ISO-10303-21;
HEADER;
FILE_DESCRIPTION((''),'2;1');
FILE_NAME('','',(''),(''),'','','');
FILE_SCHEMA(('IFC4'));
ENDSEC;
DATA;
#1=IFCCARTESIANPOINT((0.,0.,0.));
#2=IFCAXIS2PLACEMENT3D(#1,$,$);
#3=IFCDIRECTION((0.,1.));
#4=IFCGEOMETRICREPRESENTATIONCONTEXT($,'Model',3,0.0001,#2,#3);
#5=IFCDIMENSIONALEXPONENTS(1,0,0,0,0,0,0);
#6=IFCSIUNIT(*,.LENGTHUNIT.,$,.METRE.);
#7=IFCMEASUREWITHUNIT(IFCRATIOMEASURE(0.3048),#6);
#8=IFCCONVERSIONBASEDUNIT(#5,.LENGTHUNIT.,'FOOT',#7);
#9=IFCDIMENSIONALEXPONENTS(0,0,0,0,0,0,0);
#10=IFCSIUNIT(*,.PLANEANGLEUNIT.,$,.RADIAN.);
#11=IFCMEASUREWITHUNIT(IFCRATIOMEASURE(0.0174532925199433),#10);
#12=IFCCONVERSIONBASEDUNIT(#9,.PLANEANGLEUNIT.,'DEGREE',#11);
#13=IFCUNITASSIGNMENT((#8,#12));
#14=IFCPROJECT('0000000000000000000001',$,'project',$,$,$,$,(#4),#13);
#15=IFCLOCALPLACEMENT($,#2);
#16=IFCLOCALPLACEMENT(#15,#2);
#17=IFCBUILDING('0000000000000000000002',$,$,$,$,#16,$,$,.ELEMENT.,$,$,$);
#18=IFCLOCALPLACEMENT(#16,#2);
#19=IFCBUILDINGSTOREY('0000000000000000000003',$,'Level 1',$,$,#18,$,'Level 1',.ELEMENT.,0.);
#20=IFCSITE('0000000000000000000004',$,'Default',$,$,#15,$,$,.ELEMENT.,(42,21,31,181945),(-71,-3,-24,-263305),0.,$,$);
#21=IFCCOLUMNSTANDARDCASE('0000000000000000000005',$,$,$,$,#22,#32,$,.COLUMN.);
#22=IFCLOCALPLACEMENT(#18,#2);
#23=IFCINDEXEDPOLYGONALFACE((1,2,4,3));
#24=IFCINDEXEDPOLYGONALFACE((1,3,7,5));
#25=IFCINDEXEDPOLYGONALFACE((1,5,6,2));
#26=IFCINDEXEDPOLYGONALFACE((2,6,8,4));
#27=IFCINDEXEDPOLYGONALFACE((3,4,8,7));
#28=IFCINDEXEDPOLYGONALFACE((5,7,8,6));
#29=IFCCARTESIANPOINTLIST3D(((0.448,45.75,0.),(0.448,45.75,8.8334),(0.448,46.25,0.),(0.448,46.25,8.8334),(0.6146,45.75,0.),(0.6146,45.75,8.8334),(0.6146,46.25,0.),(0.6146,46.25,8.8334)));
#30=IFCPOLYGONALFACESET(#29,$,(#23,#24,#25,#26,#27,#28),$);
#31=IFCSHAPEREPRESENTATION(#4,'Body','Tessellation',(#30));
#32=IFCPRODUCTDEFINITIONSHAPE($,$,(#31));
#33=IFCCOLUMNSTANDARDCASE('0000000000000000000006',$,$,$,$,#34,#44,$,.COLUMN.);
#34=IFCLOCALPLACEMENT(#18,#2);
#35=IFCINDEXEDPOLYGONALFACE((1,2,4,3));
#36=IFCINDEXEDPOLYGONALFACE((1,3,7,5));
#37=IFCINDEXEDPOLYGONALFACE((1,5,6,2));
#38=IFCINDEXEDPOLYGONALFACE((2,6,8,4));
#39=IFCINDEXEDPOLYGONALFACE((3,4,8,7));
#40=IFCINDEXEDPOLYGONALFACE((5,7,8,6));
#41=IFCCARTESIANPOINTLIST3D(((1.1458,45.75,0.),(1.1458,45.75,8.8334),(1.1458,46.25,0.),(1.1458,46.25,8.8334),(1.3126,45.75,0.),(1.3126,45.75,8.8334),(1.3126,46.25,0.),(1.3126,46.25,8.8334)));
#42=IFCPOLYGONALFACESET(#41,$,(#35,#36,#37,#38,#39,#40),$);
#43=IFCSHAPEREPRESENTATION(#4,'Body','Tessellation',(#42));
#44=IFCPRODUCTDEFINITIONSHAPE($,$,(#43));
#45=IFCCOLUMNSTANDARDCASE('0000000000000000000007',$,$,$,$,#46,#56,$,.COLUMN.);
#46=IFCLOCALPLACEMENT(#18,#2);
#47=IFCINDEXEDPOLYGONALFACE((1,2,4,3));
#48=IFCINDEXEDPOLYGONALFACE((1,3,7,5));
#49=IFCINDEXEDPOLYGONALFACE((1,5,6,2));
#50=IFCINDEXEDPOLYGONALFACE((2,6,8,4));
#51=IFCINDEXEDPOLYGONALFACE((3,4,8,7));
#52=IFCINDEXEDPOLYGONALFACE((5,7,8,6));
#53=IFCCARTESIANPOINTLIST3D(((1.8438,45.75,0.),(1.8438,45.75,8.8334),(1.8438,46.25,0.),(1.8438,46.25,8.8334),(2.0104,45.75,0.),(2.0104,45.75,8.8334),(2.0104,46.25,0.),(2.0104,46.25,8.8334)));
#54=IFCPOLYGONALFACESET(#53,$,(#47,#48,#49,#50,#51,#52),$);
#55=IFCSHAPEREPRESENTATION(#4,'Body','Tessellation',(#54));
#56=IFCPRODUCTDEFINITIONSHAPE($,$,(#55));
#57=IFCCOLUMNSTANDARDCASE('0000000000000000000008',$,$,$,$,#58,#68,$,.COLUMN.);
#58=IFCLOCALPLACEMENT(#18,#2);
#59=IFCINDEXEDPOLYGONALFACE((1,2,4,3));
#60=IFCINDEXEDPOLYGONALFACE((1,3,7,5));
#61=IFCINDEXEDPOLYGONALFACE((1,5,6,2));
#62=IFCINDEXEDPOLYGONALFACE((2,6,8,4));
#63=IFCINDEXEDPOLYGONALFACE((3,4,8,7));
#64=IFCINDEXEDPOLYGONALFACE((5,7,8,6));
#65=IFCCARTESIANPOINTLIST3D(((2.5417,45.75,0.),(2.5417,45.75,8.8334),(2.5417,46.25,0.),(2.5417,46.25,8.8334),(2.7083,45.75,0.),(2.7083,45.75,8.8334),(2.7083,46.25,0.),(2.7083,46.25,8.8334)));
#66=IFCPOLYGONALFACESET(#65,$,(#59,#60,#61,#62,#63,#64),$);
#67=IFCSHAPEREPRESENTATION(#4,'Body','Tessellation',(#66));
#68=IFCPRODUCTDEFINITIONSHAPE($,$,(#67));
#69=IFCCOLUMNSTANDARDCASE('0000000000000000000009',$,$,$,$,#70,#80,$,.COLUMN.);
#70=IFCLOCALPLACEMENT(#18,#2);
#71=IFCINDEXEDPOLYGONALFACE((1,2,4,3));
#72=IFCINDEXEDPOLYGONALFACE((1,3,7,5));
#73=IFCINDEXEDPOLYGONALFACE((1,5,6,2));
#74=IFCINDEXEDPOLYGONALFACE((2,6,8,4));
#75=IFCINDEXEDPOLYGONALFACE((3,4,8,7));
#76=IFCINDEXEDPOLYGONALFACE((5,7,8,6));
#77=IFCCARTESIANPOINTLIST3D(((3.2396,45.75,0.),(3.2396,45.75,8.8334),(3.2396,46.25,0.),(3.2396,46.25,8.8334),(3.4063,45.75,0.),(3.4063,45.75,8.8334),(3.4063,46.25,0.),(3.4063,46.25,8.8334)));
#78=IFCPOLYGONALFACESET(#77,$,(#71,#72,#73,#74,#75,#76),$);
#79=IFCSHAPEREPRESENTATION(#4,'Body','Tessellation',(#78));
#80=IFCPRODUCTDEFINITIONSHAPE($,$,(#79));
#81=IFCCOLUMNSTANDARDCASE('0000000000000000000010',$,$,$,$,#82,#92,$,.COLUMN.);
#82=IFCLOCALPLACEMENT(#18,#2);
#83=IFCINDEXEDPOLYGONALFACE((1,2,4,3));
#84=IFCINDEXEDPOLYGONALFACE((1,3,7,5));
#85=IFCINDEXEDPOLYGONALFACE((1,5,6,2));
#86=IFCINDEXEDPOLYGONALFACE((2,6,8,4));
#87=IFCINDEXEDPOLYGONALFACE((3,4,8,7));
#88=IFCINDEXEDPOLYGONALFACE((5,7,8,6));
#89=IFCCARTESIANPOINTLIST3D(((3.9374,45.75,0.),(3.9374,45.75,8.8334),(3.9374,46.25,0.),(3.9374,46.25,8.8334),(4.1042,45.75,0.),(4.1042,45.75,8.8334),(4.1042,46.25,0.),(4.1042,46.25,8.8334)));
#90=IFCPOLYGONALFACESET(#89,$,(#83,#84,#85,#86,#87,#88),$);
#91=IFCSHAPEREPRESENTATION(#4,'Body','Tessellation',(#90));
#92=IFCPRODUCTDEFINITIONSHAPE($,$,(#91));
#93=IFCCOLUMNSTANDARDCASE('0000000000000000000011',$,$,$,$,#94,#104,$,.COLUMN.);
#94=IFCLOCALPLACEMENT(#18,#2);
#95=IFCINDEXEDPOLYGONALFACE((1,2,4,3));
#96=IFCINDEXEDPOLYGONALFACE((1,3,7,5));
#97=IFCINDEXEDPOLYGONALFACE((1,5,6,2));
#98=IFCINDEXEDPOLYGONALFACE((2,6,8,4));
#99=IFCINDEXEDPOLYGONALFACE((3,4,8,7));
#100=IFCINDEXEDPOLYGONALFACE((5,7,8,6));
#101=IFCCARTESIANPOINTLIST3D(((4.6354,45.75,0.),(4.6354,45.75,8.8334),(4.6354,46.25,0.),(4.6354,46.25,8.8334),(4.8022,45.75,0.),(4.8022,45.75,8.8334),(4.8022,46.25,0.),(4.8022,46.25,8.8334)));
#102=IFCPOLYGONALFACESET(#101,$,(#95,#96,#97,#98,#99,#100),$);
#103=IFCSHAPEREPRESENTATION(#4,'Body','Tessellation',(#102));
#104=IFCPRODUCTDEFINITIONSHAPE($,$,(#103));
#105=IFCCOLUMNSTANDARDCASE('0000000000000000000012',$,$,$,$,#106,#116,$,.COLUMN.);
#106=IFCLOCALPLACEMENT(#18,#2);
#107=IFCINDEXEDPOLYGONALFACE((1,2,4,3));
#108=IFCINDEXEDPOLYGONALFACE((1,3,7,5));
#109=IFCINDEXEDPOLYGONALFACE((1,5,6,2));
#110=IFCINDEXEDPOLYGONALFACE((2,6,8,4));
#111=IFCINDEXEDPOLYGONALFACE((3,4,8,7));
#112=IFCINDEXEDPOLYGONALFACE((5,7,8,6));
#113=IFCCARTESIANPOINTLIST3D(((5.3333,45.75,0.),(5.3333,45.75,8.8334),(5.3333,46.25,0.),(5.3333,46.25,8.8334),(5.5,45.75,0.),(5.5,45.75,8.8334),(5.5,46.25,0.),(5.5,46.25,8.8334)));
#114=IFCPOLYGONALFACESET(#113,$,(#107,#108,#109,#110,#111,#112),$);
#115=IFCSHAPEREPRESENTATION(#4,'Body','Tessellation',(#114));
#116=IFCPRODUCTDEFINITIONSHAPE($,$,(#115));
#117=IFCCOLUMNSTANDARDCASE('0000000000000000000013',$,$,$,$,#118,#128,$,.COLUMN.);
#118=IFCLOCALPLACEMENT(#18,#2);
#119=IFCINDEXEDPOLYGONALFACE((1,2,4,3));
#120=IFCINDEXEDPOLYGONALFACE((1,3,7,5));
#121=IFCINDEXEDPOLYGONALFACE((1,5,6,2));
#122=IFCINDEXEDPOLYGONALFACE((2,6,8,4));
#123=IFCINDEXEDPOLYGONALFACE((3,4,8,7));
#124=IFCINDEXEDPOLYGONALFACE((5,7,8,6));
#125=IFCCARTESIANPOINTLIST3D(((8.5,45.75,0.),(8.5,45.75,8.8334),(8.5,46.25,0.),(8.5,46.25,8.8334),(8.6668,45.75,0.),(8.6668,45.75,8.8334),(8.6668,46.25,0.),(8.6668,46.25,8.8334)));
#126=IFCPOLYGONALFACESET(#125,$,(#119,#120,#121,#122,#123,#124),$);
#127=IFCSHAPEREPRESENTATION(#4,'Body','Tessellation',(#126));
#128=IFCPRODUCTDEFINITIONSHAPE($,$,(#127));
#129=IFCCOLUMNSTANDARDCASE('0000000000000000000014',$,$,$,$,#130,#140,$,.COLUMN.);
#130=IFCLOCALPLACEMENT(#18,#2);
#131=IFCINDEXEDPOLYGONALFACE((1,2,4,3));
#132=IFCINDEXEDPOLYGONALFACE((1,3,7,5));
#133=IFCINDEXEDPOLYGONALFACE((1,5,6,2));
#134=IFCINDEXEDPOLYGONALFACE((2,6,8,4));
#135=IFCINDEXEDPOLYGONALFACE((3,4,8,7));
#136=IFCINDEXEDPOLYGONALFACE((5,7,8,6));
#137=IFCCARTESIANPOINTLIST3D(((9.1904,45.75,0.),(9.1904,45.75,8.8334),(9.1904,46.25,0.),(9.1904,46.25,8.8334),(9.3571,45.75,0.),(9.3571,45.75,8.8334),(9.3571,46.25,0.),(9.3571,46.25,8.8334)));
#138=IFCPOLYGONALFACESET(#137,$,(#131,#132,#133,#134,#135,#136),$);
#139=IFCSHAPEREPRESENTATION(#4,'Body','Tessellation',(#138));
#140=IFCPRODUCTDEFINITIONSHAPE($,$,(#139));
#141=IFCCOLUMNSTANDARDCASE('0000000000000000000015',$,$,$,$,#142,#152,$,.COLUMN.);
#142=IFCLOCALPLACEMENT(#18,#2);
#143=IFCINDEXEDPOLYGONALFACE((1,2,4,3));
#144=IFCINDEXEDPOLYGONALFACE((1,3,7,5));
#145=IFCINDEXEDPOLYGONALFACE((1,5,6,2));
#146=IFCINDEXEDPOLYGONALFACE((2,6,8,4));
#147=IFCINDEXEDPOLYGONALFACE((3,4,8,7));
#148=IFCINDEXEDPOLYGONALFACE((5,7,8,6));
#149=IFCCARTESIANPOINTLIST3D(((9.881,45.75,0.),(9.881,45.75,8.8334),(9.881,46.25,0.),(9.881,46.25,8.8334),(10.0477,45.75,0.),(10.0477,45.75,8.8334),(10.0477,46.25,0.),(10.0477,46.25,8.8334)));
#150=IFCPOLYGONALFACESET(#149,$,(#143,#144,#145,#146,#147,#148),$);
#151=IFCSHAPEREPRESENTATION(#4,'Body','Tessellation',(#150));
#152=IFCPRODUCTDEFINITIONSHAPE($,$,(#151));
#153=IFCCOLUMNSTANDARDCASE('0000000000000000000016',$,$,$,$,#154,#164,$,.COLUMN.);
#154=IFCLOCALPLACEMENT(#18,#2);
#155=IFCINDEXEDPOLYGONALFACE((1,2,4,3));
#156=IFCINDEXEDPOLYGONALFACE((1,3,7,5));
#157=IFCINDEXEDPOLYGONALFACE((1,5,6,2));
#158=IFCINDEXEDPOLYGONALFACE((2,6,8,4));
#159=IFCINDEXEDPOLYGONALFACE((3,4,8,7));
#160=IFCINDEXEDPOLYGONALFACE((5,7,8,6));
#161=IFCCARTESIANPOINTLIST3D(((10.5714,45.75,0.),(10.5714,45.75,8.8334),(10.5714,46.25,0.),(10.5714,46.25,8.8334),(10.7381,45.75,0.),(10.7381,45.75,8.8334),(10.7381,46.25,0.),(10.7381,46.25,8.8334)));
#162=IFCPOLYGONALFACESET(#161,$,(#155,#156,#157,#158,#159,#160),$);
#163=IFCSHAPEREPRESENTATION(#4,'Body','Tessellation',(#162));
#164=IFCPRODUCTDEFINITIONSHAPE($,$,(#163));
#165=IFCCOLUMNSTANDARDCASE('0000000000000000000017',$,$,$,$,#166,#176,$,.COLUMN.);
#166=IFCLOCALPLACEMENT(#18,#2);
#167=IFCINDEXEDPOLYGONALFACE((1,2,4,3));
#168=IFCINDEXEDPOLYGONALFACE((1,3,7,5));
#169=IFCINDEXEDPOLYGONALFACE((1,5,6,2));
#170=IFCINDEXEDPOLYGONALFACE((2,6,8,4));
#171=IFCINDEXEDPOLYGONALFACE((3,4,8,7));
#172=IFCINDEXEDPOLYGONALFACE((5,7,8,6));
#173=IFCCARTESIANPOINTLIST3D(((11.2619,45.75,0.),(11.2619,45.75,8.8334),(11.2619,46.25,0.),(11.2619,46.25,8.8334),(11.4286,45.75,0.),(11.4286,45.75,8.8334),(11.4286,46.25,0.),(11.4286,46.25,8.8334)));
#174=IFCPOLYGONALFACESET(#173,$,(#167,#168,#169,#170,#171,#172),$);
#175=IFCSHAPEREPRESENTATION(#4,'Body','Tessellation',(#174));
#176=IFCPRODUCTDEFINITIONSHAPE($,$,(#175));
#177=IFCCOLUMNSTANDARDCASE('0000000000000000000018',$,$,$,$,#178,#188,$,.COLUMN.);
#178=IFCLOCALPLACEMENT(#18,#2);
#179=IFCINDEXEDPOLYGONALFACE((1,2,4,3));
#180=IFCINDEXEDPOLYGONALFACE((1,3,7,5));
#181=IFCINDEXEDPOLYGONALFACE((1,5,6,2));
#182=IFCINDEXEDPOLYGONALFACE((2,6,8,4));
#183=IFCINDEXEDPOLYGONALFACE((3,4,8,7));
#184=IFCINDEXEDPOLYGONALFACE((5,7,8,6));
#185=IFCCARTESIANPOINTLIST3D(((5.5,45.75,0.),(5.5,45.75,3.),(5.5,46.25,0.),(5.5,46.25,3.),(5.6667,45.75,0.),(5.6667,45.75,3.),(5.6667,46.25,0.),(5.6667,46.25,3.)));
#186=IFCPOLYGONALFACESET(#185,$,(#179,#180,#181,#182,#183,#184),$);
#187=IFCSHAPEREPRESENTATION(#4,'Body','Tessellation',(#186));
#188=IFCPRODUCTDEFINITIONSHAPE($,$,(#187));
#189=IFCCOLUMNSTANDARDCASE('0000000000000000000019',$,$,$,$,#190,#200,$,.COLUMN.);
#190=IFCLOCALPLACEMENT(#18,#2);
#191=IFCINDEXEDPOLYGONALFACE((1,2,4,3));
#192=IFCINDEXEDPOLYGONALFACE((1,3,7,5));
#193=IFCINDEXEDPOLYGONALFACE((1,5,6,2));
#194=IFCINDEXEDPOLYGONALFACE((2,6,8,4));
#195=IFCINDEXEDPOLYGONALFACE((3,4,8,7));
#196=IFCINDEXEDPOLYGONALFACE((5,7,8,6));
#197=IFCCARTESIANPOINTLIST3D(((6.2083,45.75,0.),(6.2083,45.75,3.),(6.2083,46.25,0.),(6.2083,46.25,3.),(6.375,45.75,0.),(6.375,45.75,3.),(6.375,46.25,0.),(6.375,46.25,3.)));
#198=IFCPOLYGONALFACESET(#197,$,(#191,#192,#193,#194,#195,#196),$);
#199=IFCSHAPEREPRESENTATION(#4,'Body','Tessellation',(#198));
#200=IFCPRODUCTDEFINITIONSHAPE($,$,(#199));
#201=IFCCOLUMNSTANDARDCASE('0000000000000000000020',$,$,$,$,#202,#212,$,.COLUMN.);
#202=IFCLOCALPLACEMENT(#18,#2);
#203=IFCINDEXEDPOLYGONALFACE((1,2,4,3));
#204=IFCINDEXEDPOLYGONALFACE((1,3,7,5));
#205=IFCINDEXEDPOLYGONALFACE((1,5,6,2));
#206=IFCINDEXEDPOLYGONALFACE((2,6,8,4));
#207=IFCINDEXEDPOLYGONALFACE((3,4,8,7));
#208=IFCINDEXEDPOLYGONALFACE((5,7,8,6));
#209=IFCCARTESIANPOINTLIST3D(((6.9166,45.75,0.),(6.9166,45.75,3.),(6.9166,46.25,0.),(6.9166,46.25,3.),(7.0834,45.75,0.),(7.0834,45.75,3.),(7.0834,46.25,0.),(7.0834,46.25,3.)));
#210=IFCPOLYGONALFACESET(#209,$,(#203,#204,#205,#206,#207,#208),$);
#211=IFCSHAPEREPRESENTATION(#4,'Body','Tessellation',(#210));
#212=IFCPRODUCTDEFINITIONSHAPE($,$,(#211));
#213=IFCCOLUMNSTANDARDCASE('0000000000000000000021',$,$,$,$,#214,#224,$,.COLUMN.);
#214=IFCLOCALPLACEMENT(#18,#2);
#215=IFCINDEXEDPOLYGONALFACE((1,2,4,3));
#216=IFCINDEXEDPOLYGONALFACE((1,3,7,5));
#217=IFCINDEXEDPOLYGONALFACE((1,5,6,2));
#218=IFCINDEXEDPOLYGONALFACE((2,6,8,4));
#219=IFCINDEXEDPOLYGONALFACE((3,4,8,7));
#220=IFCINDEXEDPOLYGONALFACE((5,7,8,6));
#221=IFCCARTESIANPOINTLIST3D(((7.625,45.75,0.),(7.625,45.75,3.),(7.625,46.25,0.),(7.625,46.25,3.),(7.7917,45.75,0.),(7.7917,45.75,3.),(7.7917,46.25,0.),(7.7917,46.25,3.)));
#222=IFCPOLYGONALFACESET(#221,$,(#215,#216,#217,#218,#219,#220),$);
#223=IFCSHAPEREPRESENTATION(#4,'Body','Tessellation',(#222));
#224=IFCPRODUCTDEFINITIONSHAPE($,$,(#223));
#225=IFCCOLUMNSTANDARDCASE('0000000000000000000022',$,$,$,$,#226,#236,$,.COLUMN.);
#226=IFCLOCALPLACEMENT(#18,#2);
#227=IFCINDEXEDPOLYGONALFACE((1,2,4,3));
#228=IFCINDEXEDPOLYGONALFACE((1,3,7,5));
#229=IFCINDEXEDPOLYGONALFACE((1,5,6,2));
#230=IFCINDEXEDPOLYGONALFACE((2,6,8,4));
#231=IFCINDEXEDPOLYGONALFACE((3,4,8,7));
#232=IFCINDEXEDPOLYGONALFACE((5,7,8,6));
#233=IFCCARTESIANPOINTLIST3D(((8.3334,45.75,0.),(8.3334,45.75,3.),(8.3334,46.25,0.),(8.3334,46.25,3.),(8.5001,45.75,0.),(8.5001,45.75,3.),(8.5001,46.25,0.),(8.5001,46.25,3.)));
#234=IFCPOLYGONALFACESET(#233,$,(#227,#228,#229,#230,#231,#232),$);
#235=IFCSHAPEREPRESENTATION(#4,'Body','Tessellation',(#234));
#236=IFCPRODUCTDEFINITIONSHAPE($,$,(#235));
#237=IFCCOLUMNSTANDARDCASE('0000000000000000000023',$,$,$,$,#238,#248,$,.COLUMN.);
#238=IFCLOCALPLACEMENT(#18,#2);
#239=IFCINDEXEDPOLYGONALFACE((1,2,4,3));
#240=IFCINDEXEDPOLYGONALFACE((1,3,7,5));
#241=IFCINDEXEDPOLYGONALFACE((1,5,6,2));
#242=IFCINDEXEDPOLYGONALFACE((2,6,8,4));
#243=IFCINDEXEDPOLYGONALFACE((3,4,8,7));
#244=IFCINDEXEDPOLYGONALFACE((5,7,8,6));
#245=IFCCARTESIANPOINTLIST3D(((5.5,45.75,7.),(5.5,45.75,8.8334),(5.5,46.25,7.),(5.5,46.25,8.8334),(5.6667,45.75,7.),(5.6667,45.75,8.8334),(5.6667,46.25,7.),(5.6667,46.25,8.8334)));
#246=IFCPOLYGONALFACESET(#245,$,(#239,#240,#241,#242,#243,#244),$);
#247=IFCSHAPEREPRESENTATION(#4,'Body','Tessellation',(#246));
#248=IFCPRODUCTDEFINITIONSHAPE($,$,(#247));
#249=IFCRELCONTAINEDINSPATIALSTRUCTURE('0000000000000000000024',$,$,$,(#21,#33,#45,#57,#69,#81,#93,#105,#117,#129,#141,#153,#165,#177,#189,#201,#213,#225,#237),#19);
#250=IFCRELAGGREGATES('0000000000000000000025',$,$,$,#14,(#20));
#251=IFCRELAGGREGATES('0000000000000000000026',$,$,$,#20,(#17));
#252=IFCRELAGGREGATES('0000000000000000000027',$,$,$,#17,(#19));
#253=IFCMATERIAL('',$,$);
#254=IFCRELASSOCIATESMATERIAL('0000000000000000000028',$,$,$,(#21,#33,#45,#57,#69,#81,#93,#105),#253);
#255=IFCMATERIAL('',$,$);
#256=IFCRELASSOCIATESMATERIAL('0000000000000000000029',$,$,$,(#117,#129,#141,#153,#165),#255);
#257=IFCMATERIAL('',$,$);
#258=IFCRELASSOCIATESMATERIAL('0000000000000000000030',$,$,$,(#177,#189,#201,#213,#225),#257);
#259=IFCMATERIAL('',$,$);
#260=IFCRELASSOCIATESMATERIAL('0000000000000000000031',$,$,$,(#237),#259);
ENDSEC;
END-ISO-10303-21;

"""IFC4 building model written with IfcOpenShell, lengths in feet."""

from ifc_helpers import new_model, entity, si_unit, converted_unit, direction, frame, origin, place, context, project, spatial, rectangle, extrude, material, element, save


model = new_model("IFC4")

# Units and contexts
model_context = context("Model", 3, precision=0.0001, world=origin(), true_north=direction((0.0, 1.0)))
ifc_project = project(units=[converted_unit("LENGTHUNIT", "FOOT", entity("IfcRatioMeasure", 0.3048), si_unit("LENGTHUNIT", "METRE"), dimensions=[1, 0, 0, 0, 0, 0, 0]), converted_unit("PLANEANGLEUNIT", "DEGREE", entity("IfcRatioMeasure", 0.0174532925199433), si_unit("PLANEANGLEUNIT", "RADIAN"), dimensions=[0, 0, 0, 0, 0, 0, 0])], contexts=[model_context])

# Site, building, storey
site_placement = place(None, origin())
site = spatial("IfcSite", under=ifc_project, at=site_placement, Name="Default", CompositionType="ELEMENT", RefLatitude=(42, 21, 31, 181945), RefLongitude=(-71, -3, -24, -263305), RefElevation=0.0)
building_placement = place(site_placement, origin())
building = spatial("IfcBuilding", under=site, at=building_placement, CompositionType="ELEMENT")
storey_placement = place(building_placement, origin())
storey = spatial("IfcBuildingStorey", under=building, at=storey_placement, Name="Level 1", LongName="Level 1", CompositionType="ELEMENT", Elevation=0.0)

# Columns
ifc_material_1 = material(Name="")
placement_1 = place(storey_placement, frame((-0.25, 46.0, 0.0)))
for number, where, z_axis, x_axis in (
    (1, (0.7813, 0.0, 0.0), (0.0, 0.0, 1.0), (1.0, 0.0, 0.0)),
    (2, (1.4792, 0.0, 0.0), (0.0, 0.0, 1.0), (1.0, 0.0, 0.0)),
    (3, (2.1771, 0.0, 0.0), (0.0, 0.0, 1.0), (1.0, 0.0, 0.0)),
    (4, (2.875, 0.0, 0.0), (0.0, 0.0, 1.0), (1.0, 0.0, 0.0)),
    (5, (3.5729, 0.0, 0.0), (0.0, 0.0, 1.0), (1.0, 0.0, 0.0)),
    (6, (4.2708, 0.0, 0.0), (0.0, 0.0, 1.0), (1.0, 0.0, 0.0)),
    (7, (4.9688, 0.0, 0.0), (0.0, 0.0, 1.0), (1.0, 0.0, 0.0)),
    (8, (5.6667, 0.0, 0.0), (0.0, 0.0, 1.0), (1.0, 0.0, 0.0)),
):
    element("IfcColumnStandardCase", number, at=place(placement_1, frame(where, z_axis=z_axis, x_axis=x_axis)), inside=storey, material=ifc_material_1, PredefinedType="COLUMN", context=model_context, shape_type="SweptSolid", body=[
        extrude(rectangle(XDim=0.1667, YDim=0.5), origin(), (0.0, 0.0, 1.0), 8.8334),
    ])
ifc_material_2 = material(Name="")
for number, where, z_axis, x_axis in (
    (9, (8.8334, 0.0, 0.0), (0.0, 0.0, 1.0), (1.0, 0.0, 0.0)),
    (10, (9.5238, 0.0, 0.0), (0.0, 0.0, 1.0), (1.0, 0.0, 0.0)),
    (11, (10.2143, 0.0, 0.0), (0.0, 0.0, 1.0), (1.0, 0.0, 0.0)),
    (12, (10.9048, 0.0, 0.0), (0.0, 0.0, 1.0), (1.0, 0.0, 0.0)),
    (13, (11.5953, 0.0, 0.0), (0.0, 0.0, 1.0), (1.0, 0.0, 0.0)),
):
    element("IfcColumnStandardCase", number, at=place(placement_1, frame(where, z_axis=z_axis, x_axis=x_axis)), inside=storey, material=ifc_material_2, PredefinedType="COLUMN", context=model_context, shape_type="SweptSolid", body=[
        extrude(rectangle(XDim=0.1667, YDim=0.5), origin(), (0.0, 0.0, 1.0), 8.8334),
    ])
ifc_material_3 = material(Name="")
for number, where, z_axis, x_axis in (
    (14, (5.8333, 0.0, 0.0), (0.0, 0.0, 1.0), (1.0, 0.0, 0.0)),
    (15, (6.5417, 0.0, 0.0), (0.0, 0.0, 1.0), (1.0, 0.0, 0.0)),
    (16, (7.25, 0.0, 0.0), (0.0, 0.0, 1.0), (1.0, 0.0, 0.0)),
    (17, (7.9583, 0.0, 0.0), (0.0, 0.0, 1.0), (1.0, 0.0, 0.0)),
    (18, (8.6667, 0.0, 0.0), (0.0, 0.0, 1.0), (1.0, 0.0, 0.0)),
):
    element("IfcColumnStandardCase", number, at=place(placement_1, frame(where, z_axis=z_axis, x_axis=x_axis)), inside=storey, material=ifc_material_3, PredefinedType="COLUMN", context=model_context, shape_type="SweptSolid", body=[
        extrude(rectangle(XDim=0.1667, YDim=0.5), origin(), (0.0, 0.0, 1.0), 3.0),
    ])
ifc_material_4 = material(Name="")
for number, where, z_axis, x_axis in (
    (19, (5.8333, 0.0, 7.0), (0.0, 0.0, 1.0), (1.0, 0.0, 0.0)),
):
    element("IfcColumnStandardCase", number, at=place(placement_1, frame(where, z_axis=z_axis, x_axis=x_axis)), inside=storey, material=ifc_material_4, PredefinedType="COLUMN", context=model_context, shape_type="SweptSolid", body=[
        extrude(rectangle(XDim=0.1667, YDim=0.5), origin(), (0.0, 0.0, 1.0), 1.8334),
    ])

save(model, "model.ifc")
